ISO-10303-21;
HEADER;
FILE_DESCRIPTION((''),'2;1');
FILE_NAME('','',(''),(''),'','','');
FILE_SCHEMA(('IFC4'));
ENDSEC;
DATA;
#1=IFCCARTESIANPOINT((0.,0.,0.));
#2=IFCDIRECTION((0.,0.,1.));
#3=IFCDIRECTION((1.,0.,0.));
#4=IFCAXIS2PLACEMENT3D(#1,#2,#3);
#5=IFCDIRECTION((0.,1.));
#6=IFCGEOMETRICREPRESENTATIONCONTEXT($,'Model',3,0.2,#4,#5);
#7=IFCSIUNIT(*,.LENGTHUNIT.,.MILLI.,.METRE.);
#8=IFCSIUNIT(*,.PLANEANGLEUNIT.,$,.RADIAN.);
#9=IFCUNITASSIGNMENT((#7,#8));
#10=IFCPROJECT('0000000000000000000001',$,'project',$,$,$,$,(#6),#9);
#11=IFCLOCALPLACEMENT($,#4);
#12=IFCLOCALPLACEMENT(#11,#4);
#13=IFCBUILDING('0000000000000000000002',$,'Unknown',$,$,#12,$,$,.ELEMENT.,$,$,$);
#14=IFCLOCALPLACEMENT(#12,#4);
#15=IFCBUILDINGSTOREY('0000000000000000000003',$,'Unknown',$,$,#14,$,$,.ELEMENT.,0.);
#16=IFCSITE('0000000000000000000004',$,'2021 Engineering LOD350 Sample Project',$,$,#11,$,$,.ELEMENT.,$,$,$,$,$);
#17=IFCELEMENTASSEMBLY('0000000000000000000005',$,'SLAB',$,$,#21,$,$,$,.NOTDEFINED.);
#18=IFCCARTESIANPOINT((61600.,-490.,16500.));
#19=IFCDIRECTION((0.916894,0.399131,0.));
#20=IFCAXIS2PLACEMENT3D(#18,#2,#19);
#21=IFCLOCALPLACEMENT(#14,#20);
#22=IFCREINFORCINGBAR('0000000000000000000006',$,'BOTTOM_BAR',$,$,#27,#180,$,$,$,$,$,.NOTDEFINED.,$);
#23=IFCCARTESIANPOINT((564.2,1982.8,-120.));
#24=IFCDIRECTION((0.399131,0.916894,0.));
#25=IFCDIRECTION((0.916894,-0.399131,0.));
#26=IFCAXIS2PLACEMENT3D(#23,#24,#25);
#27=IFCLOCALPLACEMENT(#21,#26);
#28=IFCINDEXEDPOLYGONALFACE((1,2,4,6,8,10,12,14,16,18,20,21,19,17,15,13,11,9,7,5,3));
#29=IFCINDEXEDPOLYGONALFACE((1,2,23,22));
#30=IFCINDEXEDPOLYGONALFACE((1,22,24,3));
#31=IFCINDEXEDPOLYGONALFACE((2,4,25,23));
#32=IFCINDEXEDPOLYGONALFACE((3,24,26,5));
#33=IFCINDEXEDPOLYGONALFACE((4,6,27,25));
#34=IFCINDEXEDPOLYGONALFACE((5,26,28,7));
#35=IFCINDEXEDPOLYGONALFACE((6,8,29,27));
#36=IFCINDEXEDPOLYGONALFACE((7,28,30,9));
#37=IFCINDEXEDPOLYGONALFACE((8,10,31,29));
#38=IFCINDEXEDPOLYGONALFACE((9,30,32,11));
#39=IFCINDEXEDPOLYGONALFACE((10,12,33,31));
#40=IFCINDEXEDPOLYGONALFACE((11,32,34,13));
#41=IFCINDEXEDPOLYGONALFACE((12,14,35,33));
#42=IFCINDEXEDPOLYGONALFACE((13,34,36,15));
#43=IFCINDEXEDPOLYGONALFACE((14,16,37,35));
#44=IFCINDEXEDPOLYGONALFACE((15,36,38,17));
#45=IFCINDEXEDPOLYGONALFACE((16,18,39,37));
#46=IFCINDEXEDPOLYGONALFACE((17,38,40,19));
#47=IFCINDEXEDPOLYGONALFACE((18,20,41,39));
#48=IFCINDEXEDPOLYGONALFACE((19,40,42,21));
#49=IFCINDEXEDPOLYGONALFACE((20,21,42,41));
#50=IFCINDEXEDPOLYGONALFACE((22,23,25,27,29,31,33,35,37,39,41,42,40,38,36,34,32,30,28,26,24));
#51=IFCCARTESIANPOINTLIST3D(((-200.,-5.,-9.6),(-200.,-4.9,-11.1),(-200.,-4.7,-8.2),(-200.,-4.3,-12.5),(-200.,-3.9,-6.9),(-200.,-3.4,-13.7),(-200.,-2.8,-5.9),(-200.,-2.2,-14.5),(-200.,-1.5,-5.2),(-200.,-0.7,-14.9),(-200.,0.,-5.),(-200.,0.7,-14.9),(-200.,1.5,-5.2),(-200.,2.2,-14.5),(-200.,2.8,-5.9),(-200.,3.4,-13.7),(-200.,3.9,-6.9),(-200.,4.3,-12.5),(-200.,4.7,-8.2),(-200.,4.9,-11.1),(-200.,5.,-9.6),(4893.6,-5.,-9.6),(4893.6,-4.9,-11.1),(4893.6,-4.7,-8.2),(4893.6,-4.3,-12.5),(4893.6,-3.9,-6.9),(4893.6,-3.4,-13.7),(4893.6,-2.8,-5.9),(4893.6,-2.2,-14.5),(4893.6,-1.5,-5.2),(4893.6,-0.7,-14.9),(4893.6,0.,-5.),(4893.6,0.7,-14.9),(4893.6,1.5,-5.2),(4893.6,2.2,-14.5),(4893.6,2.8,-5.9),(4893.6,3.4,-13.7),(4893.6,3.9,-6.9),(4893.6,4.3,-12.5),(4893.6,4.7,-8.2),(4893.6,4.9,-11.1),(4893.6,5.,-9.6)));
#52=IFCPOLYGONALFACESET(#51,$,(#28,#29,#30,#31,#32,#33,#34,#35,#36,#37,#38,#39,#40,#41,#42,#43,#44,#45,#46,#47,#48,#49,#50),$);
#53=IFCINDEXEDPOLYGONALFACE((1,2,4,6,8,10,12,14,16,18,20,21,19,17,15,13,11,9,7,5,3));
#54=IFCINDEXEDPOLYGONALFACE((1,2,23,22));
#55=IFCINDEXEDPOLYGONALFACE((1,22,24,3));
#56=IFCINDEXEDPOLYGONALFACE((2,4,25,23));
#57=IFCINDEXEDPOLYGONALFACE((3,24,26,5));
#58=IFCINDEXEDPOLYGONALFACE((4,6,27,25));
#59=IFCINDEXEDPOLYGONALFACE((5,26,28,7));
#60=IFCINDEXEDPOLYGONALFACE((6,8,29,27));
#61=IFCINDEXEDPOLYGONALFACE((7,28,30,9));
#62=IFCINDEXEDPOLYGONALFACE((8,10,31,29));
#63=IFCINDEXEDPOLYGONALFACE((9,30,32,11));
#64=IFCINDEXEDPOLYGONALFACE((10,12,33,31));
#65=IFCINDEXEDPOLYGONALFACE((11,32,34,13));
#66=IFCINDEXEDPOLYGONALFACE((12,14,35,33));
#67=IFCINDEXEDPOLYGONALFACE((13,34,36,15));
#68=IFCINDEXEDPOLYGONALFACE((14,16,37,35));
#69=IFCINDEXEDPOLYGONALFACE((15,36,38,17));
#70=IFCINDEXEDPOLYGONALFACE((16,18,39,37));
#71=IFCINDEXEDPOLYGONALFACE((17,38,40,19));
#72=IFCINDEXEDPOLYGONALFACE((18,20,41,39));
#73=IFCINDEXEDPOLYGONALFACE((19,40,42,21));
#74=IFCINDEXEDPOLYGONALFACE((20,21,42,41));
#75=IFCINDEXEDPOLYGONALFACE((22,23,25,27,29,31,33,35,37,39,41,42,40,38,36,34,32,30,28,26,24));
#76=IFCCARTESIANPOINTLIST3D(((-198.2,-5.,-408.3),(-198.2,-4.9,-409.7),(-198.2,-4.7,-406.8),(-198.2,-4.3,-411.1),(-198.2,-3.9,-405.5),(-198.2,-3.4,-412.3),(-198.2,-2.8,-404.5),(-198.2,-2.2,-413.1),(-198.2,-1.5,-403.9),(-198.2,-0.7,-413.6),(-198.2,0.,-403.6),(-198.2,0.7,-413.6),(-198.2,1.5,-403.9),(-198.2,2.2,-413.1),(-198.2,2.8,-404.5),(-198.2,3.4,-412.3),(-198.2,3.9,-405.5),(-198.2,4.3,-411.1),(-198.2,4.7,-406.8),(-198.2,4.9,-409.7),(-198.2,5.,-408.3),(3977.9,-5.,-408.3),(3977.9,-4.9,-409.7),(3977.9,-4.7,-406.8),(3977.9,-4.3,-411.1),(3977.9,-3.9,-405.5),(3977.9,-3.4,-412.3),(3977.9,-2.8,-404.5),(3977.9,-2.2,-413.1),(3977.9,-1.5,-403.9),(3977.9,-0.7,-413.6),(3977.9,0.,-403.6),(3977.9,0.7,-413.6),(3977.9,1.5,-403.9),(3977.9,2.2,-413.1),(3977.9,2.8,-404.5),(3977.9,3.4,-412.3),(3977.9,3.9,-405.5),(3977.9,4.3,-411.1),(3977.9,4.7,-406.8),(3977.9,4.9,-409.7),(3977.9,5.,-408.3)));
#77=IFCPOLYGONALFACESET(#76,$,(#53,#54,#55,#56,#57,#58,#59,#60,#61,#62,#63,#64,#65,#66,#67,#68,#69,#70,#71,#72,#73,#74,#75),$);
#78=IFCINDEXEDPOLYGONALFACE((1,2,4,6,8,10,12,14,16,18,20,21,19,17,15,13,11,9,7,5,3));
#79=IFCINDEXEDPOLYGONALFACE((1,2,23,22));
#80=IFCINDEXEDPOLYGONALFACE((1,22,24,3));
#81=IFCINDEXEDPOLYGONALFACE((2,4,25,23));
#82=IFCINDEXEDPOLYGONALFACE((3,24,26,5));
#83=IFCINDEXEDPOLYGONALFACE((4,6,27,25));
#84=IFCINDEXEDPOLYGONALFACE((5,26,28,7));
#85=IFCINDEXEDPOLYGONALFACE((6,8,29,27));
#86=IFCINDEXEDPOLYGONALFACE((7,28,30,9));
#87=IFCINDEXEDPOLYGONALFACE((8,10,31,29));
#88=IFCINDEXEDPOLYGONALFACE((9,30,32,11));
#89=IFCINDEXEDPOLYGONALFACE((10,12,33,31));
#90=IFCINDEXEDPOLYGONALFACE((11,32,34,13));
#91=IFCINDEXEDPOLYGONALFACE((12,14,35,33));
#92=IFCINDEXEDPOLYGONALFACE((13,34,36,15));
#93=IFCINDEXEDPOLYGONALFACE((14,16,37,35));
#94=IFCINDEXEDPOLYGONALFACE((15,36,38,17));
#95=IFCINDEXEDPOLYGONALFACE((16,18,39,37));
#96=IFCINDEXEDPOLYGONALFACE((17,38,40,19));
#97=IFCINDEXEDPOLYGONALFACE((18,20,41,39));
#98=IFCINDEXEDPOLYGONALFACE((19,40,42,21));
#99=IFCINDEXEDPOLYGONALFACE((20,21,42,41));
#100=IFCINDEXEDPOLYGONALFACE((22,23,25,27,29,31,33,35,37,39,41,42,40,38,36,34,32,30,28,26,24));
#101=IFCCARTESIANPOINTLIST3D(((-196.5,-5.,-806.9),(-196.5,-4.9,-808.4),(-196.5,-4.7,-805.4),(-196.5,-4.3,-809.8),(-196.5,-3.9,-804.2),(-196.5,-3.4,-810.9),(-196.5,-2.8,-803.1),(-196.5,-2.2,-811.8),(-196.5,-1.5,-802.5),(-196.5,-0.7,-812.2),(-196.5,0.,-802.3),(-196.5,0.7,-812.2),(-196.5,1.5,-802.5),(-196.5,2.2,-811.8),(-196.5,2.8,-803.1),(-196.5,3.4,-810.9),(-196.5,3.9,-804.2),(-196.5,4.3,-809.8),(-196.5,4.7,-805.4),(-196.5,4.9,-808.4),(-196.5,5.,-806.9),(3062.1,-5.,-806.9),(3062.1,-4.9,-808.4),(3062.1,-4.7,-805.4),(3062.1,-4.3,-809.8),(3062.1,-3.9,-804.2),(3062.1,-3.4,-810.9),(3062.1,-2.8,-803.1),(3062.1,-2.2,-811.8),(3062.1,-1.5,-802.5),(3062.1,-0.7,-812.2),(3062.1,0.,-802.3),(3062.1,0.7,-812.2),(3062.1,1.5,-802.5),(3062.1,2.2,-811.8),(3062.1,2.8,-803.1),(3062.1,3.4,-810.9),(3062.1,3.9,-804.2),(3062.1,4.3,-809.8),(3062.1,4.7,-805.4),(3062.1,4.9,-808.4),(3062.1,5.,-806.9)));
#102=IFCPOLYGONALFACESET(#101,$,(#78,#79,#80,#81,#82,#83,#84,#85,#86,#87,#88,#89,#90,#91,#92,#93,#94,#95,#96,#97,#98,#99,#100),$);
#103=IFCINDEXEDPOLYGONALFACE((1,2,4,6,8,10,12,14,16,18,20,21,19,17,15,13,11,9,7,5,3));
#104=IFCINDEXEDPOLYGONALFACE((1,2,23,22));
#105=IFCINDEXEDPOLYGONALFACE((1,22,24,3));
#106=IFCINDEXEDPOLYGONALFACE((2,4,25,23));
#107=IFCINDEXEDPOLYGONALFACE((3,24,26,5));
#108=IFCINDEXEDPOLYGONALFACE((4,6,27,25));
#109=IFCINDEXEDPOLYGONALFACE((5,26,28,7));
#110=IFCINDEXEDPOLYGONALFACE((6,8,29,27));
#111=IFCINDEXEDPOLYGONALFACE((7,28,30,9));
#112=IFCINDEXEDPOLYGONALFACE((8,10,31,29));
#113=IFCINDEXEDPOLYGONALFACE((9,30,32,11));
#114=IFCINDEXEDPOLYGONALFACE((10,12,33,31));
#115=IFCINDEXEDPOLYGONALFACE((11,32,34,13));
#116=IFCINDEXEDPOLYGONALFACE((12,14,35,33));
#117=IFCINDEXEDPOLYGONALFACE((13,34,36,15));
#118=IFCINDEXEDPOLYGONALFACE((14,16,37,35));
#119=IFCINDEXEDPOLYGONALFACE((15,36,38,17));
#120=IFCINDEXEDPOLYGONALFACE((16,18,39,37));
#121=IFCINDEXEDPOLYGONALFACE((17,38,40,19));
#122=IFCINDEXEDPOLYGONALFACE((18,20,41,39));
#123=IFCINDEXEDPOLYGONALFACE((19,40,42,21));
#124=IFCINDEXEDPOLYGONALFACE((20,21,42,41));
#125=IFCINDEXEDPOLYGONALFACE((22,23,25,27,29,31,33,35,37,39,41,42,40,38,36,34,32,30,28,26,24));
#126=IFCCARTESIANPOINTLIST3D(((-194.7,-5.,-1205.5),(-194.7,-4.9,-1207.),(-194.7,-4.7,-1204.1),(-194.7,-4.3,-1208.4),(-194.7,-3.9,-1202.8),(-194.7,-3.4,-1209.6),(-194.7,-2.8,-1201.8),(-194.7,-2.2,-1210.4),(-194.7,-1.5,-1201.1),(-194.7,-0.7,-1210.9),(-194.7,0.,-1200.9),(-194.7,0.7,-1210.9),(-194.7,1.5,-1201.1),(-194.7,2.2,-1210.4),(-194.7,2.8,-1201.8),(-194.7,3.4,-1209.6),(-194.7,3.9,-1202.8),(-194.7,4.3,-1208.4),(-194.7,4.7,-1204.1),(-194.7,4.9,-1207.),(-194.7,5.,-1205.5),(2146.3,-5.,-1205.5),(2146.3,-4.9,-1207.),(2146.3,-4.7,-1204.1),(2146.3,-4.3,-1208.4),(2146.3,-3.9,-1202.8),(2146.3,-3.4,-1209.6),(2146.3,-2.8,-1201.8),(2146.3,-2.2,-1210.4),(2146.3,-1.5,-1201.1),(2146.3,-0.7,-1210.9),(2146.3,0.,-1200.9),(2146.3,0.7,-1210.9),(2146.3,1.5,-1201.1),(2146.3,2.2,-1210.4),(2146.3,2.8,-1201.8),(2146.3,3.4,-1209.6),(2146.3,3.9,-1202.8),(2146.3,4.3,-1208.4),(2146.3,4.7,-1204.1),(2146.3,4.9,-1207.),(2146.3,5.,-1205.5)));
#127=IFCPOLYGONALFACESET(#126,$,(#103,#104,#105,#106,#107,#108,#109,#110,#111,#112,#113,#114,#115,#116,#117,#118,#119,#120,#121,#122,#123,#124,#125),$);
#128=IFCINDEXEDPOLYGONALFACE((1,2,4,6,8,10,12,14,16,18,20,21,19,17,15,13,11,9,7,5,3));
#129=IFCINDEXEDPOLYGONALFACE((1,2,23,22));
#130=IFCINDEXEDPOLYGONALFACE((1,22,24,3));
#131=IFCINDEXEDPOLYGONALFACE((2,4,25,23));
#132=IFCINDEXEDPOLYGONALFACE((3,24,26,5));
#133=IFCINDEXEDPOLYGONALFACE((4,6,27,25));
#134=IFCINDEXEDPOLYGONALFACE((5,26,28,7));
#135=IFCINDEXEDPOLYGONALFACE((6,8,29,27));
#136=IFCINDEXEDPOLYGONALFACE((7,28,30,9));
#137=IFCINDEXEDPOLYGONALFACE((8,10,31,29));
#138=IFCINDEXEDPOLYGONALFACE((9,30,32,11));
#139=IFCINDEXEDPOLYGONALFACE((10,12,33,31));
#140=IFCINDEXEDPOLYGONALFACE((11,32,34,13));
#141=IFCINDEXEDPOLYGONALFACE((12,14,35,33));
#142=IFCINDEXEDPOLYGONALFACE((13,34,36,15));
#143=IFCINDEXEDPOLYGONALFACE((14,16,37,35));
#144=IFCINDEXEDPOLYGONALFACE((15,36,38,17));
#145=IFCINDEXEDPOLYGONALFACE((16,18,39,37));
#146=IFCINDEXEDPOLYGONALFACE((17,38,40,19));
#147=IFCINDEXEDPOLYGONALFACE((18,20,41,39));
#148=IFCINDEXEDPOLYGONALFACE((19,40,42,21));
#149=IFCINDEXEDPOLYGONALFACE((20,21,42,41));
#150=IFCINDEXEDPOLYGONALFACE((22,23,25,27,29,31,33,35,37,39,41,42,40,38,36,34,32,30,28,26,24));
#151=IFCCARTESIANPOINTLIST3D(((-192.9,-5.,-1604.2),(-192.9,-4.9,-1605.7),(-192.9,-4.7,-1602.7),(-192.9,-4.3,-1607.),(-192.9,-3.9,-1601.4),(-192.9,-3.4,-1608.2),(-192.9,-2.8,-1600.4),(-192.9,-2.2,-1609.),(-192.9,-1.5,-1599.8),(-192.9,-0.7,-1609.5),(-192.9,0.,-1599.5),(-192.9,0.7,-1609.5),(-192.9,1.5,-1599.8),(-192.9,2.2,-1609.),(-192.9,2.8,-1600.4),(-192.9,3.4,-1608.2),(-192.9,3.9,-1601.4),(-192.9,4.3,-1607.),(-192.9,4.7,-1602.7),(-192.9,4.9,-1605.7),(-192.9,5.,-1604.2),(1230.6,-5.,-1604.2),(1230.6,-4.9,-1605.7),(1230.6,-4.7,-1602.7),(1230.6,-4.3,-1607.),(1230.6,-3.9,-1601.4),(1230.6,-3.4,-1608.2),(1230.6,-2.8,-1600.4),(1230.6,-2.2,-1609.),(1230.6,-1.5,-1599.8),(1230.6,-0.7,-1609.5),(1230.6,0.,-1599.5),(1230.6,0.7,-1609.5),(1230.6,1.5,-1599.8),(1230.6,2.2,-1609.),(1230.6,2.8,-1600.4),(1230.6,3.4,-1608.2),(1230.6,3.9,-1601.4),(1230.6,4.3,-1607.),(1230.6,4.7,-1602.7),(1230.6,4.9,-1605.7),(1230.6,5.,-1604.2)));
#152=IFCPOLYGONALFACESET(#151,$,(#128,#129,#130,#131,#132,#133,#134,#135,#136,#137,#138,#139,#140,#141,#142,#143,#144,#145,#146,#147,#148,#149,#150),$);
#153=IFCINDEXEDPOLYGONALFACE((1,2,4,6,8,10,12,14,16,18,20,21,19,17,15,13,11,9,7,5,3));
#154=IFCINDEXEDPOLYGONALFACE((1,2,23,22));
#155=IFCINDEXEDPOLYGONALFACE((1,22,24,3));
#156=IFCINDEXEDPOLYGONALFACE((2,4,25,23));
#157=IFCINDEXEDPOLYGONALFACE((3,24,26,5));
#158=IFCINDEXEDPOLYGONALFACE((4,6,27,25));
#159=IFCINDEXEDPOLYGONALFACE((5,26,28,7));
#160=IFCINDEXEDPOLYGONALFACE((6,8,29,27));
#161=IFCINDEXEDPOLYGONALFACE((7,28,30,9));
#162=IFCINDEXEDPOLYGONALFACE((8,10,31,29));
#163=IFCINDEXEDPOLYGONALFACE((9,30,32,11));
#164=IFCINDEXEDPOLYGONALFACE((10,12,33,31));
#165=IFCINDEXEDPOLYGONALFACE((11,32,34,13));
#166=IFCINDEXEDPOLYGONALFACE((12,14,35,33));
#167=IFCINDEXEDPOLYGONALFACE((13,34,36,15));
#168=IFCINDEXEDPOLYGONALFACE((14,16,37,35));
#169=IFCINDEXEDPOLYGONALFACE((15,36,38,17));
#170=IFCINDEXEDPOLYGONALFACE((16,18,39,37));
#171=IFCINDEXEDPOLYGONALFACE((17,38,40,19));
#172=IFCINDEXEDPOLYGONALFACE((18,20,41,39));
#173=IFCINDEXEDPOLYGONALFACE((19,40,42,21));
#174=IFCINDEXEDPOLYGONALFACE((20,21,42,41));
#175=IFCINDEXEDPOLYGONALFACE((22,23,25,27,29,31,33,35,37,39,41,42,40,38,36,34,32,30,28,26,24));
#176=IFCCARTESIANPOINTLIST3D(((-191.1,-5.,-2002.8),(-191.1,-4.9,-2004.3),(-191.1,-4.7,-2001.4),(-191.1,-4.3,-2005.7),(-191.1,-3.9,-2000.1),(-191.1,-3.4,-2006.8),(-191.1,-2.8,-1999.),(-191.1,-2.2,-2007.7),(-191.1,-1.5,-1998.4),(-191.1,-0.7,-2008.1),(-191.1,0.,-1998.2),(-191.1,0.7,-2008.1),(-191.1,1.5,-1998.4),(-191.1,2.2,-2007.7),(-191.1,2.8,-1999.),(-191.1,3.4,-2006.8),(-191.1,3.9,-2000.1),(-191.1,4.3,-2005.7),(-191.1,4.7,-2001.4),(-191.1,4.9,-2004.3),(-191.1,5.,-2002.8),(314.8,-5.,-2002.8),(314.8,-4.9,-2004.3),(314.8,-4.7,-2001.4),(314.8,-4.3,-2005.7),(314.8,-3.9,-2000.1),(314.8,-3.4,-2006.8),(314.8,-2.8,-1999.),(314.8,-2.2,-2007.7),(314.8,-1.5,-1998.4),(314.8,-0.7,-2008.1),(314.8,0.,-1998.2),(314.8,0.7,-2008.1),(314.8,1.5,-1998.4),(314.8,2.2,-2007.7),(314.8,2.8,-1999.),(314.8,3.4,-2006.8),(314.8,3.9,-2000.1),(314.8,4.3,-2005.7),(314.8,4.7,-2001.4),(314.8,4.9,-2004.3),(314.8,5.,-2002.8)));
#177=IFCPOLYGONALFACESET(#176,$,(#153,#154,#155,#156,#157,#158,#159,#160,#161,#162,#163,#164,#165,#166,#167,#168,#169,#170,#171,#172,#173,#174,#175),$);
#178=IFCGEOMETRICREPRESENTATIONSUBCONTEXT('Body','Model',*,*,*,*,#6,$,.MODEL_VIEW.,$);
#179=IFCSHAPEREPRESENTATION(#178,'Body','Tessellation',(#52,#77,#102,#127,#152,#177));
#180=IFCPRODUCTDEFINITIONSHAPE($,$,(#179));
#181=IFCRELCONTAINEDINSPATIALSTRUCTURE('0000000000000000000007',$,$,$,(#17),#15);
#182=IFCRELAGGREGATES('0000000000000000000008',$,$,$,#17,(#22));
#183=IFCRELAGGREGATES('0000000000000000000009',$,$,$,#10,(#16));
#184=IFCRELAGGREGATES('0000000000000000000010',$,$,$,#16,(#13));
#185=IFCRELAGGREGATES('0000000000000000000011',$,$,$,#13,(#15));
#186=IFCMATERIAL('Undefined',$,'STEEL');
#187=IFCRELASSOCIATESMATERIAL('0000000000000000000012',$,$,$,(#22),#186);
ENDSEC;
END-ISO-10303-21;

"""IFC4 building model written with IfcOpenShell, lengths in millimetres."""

from ifc_helpers import new_model, entity, si_unit, direction, frame, origin_with_axes, place, context, subcontext, project, spatial, material, element, aggregate, save


model = new_model("IFC4")

# Units and contexts
model_context = context("Model", 3, precision=0.2, world=origin_with_axes(), true_north=direction((0.0, 1.0)))
body_context = subcontext(model_context, "Body", "Model", "MODEL_VIEW")
ifc_project = project(units=[si_unit("LENGTHUNIT", "METRE", prefix="MILLI"), si_unit("PLANEANGLEUNIT", "RADIAN")], contexts=[model_context])

# Site, building, storey
site_placement = place(None, origin_with_axes())
site = spatial("IfcSite", under=ifc_project, at=site_placement, Name="2021 Engineering LOD350 Sample Project", CompositionType="ELEMENT")
building_placement = place(site_placement, origin_with_axes())
building = spatial("IfcBuilding", under=site, at=building_placement, Name="Unknown", CompositionType="ELEMENT")
storey_placement = place(building_placement, origin_with_axes())
storey = spatial("IfcBuildingStorey", under=building, at=storey_placement, Name="Unknown", CompositionType="ELEMENT", Elevation=0.0)

# Element assembly
assembly_1_placement = place(storey_placement, frame((61600.0, -490.0, 16500.0), z_axis=(0.0, 0.0, 1.0), x_axis=(0.916894, 0.399131, 0.0)))
assembly_1 = element("IfcElementAssembly", 1, at=assembly_1_placement, inside=storey, Name="SLAB", PredefinedType="NOTDEFINED")
ifc_material_1 = material(Name="Undefined", Category="STEEL")

# Reinforcing bar
reinforcing_bar_1_placement = place(assembly_1_placement, frame((564.2, 1982.8, -120.0), z_axis=(0.399131, 0.916894, 0.0), x_axis=(0.916894, -0.399131, 0.0)))
reinforcing_bar_1 = element("IfcReinforcingBar", 2, at=reinforcing_bar_1_placement, material=ifc_material_1, Name="BOTTOM_BAR", PredefinedType="NOTDEFINED", context=body_context, shape_type="AdvancedSweptSolid", body=[
    entity("IfcSweptDiskSolid", entity("IfcIndexedPolyCurve", entity("IfcCartesianPointList3D", [[-200.0, 0.0, -10.0], [4893.6, 0.0, -10.0]]), [entity("IfcLineIndex", [1, 2])]), 5.0),
    entity("IfcSweptDiskSolid", entity("IfcIndexedPolyCurve", entity("IfcCartesianPointList3D", [[-198.2, 0.0, -408.6], [3977.9, 0.0, -408.6]]), [entity("IfcLineIndex", [1, 2])]), 5.0),
    entity("IfcSweptDiskSolid", entity("IfcIndexedPolyCurve", entity("IfcCartesianPointList3D", [[-196.5, 0.0, -807.3], [3062.1, 0.0, -807.3]]), [entity("IfcLineIndex", [1, 2])]), 5.0),
    entity("IfcSweptDiskSolid", entity("IfcIndexedPolyCurve", entity("IfcCartesianPointList3D", [[-194.7, 0.0, -1205.9], [2146.3, 0.0, -1205.9]]), [entity("IfcLineIndex", [1, 2])]), 5.0),
    entity("IfcSweptDiskSolid", entity("IfcIndexedPolyCurve", entity("IfcCartesianPointList3D", [[-192.9, 0.0, -1604.5], [1230.6, 0.0, -1604.5]]), [entity("IfcLineIndex", [1, 2])]), 5.0),
    entity("IfcSweptDiskSolid", entity("IfcIndexedPolyCurve", entity("IfcCartesianPointList3D", [[-191.1, 0.0, -2003.2], [314.8, 0.0, -2003.2]]), [entity("IfcLineIndex", [1, 2])]), 5.0),
])
aggregate(assembly_1, [reinforcing_bar_1])

save(model, "model.ifc")
